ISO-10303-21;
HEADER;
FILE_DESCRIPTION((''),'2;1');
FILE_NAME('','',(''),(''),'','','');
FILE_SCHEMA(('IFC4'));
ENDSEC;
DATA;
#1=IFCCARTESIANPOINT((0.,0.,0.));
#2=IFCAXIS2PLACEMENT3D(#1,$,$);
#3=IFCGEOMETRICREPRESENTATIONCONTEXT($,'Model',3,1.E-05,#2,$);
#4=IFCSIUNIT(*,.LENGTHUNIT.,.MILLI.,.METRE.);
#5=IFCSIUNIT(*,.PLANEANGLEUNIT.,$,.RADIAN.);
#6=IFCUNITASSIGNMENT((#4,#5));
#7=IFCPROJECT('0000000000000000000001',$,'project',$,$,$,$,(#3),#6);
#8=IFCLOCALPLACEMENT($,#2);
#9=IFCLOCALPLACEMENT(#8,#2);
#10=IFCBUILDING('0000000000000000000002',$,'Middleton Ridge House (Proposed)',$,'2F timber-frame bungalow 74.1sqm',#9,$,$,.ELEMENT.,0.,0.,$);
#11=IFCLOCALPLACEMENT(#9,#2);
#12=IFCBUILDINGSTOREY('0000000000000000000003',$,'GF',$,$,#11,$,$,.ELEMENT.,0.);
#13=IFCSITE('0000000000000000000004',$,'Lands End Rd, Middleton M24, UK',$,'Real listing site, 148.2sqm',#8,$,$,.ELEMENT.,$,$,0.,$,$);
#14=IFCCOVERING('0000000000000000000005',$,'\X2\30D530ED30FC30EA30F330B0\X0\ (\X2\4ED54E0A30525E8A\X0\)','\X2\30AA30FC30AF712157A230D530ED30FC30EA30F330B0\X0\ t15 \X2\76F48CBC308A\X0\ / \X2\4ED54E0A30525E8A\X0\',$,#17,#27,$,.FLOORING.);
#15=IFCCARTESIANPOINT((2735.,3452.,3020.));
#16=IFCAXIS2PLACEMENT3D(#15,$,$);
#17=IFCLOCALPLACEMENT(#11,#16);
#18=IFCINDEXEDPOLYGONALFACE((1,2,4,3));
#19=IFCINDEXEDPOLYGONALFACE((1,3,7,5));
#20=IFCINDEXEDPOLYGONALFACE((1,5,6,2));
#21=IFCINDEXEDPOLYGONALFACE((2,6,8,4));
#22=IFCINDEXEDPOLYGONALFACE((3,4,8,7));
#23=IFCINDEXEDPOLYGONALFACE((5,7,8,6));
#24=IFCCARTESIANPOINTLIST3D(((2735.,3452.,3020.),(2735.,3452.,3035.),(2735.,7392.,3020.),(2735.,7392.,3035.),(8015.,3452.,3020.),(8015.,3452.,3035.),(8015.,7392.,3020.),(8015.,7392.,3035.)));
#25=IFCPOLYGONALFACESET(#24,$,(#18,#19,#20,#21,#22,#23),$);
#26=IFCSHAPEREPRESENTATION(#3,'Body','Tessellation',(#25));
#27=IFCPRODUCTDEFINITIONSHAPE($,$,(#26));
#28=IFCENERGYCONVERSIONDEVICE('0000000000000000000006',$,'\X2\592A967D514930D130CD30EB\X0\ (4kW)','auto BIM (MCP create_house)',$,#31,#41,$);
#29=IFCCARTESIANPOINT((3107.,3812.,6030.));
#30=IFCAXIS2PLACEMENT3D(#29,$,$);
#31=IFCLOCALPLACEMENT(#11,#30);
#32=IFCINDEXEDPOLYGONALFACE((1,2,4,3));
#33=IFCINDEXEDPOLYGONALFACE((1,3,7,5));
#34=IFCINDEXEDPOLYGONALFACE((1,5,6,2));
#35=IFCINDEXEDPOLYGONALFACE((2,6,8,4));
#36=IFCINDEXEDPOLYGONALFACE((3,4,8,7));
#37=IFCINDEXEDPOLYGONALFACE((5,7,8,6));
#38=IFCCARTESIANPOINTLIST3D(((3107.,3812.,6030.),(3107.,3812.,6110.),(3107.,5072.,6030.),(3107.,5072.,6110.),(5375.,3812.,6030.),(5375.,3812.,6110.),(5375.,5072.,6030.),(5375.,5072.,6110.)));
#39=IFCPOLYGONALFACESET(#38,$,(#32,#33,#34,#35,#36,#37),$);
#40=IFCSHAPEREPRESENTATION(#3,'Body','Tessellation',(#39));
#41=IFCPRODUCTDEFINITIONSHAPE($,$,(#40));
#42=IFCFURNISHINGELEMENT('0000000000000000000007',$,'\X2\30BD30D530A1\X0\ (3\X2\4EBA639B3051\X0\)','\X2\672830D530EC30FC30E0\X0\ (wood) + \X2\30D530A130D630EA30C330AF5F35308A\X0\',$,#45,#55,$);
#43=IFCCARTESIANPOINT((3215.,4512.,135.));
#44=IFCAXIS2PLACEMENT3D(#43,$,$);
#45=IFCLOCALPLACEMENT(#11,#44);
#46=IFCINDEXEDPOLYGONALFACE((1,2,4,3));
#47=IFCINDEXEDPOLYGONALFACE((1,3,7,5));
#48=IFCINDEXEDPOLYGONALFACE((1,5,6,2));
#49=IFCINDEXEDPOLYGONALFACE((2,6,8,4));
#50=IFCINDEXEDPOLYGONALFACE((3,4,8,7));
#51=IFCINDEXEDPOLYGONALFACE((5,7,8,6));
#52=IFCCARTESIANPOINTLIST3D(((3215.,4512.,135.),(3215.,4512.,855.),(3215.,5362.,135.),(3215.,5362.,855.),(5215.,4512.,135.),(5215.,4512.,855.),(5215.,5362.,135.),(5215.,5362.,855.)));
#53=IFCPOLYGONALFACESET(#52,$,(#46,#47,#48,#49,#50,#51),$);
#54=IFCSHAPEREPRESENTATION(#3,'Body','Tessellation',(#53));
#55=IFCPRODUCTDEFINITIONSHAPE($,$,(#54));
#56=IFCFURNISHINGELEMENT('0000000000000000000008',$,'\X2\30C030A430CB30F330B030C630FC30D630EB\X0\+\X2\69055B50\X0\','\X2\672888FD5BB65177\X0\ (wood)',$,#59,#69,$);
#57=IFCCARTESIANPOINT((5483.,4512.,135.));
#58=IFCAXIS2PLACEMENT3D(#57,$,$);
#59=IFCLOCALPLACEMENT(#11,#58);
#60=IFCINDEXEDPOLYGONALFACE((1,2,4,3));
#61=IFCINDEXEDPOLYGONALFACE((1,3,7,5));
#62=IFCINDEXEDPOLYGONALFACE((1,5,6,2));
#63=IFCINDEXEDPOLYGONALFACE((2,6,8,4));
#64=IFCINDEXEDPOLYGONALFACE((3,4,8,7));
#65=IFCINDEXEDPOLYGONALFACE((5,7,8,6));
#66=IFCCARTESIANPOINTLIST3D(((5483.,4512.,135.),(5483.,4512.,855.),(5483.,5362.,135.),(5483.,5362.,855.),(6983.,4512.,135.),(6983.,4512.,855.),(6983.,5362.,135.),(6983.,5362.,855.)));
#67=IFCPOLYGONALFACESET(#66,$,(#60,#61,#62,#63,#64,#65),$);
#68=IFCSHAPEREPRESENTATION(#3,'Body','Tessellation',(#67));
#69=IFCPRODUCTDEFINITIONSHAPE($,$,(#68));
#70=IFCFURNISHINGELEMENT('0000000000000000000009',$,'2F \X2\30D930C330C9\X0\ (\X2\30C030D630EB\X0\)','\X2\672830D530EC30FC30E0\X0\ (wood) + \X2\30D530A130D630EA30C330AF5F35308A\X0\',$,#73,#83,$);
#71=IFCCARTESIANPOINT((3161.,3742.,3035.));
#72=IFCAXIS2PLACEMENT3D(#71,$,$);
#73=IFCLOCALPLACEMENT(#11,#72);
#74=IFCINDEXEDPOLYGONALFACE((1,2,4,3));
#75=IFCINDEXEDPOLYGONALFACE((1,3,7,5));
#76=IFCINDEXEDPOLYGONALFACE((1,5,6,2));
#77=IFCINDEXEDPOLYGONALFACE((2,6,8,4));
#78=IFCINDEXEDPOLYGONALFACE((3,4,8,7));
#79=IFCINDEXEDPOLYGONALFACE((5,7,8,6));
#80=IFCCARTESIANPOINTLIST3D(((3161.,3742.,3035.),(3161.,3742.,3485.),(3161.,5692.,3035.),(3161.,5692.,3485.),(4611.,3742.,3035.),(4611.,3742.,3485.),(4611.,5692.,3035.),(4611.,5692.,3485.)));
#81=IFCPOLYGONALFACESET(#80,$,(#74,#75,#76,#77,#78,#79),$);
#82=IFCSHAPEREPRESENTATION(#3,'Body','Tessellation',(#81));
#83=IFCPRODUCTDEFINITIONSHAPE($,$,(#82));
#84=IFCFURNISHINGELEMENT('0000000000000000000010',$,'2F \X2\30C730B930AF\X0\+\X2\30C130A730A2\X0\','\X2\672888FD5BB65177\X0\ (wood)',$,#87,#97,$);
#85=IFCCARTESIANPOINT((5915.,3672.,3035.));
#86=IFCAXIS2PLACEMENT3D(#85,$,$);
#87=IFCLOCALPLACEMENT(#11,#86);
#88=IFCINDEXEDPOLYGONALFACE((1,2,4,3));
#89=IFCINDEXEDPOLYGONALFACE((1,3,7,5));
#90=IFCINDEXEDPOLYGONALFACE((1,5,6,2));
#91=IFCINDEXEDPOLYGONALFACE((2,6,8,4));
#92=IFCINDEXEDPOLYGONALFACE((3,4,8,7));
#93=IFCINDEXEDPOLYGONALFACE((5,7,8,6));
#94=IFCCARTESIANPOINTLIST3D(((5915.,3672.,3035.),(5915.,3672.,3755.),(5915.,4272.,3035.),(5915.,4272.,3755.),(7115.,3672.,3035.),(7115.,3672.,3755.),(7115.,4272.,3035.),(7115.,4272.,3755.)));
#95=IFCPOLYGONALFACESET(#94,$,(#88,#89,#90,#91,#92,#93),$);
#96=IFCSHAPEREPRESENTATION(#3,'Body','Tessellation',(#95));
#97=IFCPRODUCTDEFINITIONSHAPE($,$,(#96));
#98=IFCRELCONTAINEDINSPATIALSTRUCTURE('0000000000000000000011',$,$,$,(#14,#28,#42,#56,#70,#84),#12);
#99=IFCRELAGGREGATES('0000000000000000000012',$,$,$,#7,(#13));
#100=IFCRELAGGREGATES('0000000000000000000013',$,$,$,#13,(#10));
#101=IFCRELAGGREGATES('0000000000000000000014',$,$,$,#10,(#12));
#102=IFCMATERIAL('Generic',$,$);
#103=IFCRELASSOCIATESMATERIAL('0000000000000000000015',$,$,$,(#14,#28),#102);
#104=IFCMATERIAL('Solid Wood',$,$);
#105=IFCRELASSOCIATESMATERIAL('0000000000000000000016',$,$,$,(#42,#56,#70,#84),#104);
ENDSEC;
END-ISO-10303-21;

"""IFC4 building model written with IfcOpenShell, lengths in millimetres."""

from ifc_helpers import new_model, si_unit, frame, frame_2d, origin, place, context, project, spatial, rectangle, extrude, material, element, save


model = new_model("IFC4")

# Units and contexts
model_context = context("Model", 3, precision=1e-05, world=origin())
ifc_project = project(units=[si_unit("LENGTHUNIT", "METRE", prefix="MILLI"), si_unit("PLANEANGLEUNIT", "RADIAN")], contexts=[model_context])

# Site, building, storey
site_placement = place(None, origin())
site = spatial("IfcSite", under=ifc_project, at=site_placement, Name="Lands End Rd, Middleton M24, UK", ObjectType="Real listing site, 148.2sqm", CompositionType="ELEMENT", RefElevation=0.0)
building_placement = place(site_placement, origin())
building = spatial("IfcBuilding", under=site, at=building_placement, Name="Middleton Ridge House (Proposed)", ObjectType="2F timber-frame bungalow 74.1sqm", CompositionType="ELEMENT", ElevationOfRefHeight=0.0, ElevationOfTerrain=0.0)
storey_placement = place(building_placement, origin())
storey = spatial("IfcBuildingStorey", under=building, at=storey_placement, Name="GF", CompositionType="ELEMENT", Elevation=0.0)

# Shared definitions
ifc_material_1 = material(Name="Solid Wood")

# Covering
ifc_material_2 = material(Name="Generic")
covering_placement = place(storey_placement, frame((2735.0, 3452.0, 3020.0)))
element("IfcCovering", 1, at=covering_placement, inside=storey, material=ifc_material_2, Name="フローリング (仕上げ床)", Description="オーク無垢フローリング t15 直貼り / 仕上げ床", PredefinedType="FLOORING", context=model_context, shape_type="SweptSolid", body=[
    extrude(rectangle(XDim=5280.0, YDim=3940.0, at=frame_2d((2640.0, 1970.0))), frame((2735.0, 3452.0, 3020.0)), (0.0, 0.0, 1.0), 15.0),
])

# Energy conversion device
energy_conversion_device_placement = place(storey_placement, frame((3107.0, 3812.0, 6030.0)))
element("IfcEnergyConversionDevice", 2, at=energy_conversion_device_placement, inside=storey, material=ifc_material_2, Name="太陽光パネル (4kW)", Description="auto BIM (MCP create_house)", context=model_context, shape_type="SweptSolid", body=[
    extrude(rectangle(XDim=2268.0, YDim=1260.0, at=frame_2d((1134.0, 630.0))), frame((3107.0, 3812.0, 6030.0)), (0.0, 0.0, 1.0), 80.0),
])

# Furnishing elements
furnishing_1_placement = place(storey_placement, frame((3215.0, 4512.0, 135.0)))
element("IfcFurnishingElement", 3, at=furnishing_1_placement, inside=storey, material=ifc_material_1, Name="ソファ (3人掛け)", Description="木フレーム (wood) + ファブリック張り", context=model_context, shape_type="SweptSolid", body=[
    extrude(rectangle(XDim=2000.0, YDim=850.0, at=frame_2d((1000.0, 425.0))), frame((3215.0, 4512.0, 135.0)), (0.0, 0.0, 1.0), 720.0),
])
furnishing_2_placement = place(storey_placement, frame((5483.0, 4512.0, 135.0)))
element("IfcFurnishingElement", 4, at=furnishing_2_placement, inside=storey, material=ifc_material_1, Name="ダイニングテーブル+椅子", Description="木製家具 (wood)", context=model_context, shape_type="SweptSolid", body=[
    extrude(rectangle(XDim=1500.0, YDim=850.0, at=frame_2d((750.0, 425.0))), frame((5483.0, 4512.0, 135.0)), (0.0, 0.0, 1.0), 720.0),
])
furnishing_3_placement = place(storey_placement, frame((3161.0, 3742.0, 3035.0)))
element("IfcFurnishingElement", 5, at=furnishing_3_placement, inside=storey, material=ifc_material_1, Name="2F ベッド (ダブル)", Description="木フレーム (wood) + ファブリック張り", context=model_context, shape_type="SweptSolid", body=[
    extrude(rectangle(XDim=1450.0, YDim=1950.0, at=frame_2d((725.0, 975.0))), frame((3161.0, 3742.0, 3035.0)), (0.0, 0.0, 1.0), 450.0),
])
furnishing_4_placement = place(storey_placement, frame((5915.0, 3672.0, 3035.0)))
element("IfcFurnishingElement", 6, at=furnishing_4_placement, inside=storey, material=ifc_material_1, Name="2F デスク+チェア", Description="木製家具 (wood)", context=model_context, shape_type="SweptSolid", body=[
    extrude(rectangle(XDim=1200.0, YDim=600.0, at=frame_2d((600.0, 300.0))), frame((5915.0, 3672.0, 3035.0)), (0.0, 0.0, 1.0), 720.0),
])

save(model, "model.ifc")
